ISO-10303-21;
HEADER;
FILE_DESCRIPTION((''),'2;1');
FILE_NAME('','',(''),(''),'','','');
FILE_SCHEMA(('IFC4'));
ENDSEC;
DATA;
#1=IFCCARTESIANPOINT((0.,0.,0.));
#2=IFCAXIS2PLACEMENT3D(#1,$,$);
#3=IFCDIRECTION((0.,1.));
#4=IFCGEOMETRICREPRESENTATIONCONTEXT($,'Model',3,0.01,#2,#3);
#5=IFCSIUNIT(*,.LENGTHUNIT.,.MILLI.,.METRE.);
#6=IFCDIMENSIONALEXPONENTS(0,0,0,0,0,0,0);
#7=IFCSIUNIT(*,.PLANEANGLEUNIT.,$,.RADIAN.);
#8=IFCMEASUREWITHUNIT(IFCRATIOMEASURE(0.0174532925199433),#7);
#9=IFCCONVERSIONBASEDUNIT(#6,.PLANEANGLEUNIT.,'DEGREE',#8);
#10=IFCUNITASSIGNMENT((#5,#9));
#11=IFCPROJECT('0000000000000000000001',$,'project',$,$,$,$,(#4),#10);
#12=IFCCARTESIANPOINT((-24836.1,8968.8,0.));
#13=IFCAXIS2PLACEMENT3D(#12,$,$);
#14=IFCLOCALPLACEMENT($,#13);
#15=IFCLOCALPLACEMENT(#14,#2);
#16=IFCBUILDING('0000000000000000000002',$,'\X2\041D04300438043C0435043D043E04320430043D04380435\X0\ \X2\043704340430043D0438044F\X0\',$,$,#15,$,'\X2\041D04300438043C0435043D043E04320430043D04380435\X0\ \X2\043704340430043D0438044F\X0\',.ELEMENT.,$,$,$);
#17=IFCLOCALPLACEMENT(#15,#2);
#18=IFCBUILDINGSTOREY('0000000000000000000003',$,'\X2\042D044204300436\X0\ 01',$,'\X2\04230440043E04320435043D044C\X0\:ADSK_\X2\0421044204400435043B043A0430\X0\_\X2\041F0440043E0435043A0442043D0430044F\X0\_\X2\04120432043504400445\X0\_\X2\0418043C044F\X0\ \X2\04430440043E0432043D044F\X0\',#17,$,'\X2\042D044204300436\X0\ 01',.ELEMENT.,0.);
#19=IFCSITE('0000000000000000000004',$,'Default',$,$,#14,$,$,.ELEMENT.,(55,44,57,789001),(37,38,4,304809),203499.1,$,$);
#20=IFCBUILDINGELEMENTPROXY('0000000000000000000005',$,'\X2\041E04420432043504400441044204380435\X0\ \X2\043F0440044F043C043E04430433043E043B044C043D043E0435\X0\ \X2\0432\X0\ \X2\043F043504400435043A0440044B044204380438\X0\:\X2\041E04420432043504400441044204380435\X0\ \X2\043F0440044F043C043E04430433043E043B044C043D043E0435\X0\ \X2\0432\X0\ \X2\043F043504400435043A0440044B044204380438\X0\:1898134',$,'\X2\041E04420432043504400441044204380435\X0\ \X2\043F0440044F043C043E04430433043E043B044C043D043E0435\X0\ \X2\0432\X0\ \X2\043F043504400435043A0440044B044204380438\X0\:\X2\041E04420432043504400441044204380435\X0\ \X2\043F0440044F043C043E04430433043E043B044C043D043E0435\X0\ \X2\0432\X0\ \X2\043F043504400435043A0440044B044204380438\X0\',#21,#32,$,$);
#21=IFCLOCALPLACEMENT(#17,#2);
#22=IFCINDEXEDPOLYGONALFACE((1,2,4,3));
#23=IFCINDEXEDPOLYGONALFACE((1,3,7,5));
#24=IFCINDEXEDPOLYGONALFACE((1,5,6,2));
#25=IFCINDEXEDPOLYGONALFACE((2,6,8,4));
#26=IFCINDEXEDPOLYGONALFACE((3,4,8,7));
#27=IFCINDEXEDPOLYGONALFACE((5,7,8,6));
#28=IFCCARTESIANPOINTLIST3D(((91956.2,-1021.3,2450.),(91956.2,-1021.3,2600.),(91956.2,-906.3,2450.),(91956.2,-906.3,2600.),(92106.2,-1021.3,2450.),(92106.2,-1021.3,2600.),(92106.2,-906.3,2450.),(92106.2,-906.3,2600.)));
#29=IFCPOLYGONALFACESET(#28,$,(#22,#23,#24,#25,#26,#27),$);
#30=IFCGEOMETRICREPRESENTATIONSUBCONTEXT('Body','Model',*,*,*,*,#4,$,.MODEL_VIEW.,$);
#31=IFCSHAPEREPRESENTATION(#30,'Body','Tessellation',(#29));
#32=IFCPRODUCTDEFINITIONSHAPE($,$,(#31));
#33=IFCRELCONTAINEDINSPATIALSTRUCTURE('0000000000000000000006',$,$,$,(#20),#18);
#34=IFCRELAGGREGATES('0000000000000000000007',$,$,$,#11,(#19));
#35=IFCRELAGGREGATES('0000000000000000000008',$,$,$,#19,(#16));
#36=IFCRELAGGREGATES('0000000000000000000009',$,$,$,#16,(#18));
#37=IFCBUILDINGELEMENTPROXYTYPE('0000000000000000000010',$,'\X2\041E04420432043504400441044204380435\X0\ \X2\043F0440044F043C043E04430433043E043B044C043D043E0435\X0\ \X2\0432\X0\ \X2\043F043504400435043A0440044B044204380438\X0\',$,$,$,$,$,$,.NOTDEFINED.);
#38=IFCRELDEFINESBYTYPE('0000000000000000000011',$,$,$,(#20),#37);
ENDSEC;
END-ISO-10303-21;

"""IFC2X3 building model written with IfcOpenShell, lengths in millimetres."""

from ifc_helpers import new_model, entity, si_unit, converted_unit, direction, frame, origin, origin_2d_with_axis, place, context, subcontext, project, spatial, rectangle, extrude, type_object, element, save


model = new_model("IFC2X3")

# Units and contexts
model_context = context("Model", 3, precision=0.01, world=origin(), true_north=direction((0.0, 1.0)))
body_context = subcontext(model_context, "Body", "Model", "MODEL_VIEW")
ifc_project = project(units=[si_unit("LENGTHUNIT", "METRE", prefix="MILLI"), converted_unit("PLANEANGLEUNIT", "DEGREE", entity("IfcRatioMeasure", 0.0174532925199433), si_unit("PLANEANGLEUNIT", "RADIAN"), dimensions=[0, 0, 0, 0, 0, 0, 0])], contexts=[model_context])

# Site, building, storey
site_placement = place(None, frame((-24836.1, 8968.8, 0.0)))
site = spatial("IfcSite", under=ifc_project, at=site_placement, Name="Default", CompositionType="ELEMENT", RefLatitude=(55, 44, 57, 789001), RefLongitude=(37, 38, 4, 304809), RefElevation=203499.1)
building_placement = place(site_placement, origin())
building = spatial("IfcBuilding", under=site, at=building_placement, Name="Наименование здания", LongName="Наименование здания", CompositionType="ELEMENT")
storey_placement = place(building_placement, origin())
storey = spatial("IfcBuildingStorey", under=building, at=storey_placement, Name="Этаж 01", ObjectType="Уровень:ADSK_Стрелка_Проектная_Вверх_Имя уровня", LongName="Этаж 01", CompositionType="ELEMENT", Elevation=0.0)

# Building element proxy
building_element_proxy_type = type_object("IfcBuildingElementProxyType", Name="Отверстие прямоугольное в перекрытии", PredefinedType="NOTDEFINED")
proxy_placement = place(storey_placement, frame((91956.2, -1021.2, 2450.0)))
element("IfcBuildingElementProxy", 1, at=proxy_placement, inside=storey, type_object=building_element_proxy_type, Name="Отверстие прямоугольное в перекрытии:Отверстие прямоугольное в перекрытии:1898134", ObjectType="Отверстие прямоугольное в перекрытии:Отверстие прямоугольное в перекрытии", context=body_context, shape_type="SweptSolid", body=[
    extrude(rectangle(XDim=150.0, YDim=115.0, at=origin_2d_with_axis()), frame((75.0, 57.5, 0.0), z_axis=(0.0, 0.0, 1.0), x_axis=(-1.0, 0.0, 0.0)), (0.0, 0.0, 1.0), 150.0),
])

save(model, "model.ifc")
